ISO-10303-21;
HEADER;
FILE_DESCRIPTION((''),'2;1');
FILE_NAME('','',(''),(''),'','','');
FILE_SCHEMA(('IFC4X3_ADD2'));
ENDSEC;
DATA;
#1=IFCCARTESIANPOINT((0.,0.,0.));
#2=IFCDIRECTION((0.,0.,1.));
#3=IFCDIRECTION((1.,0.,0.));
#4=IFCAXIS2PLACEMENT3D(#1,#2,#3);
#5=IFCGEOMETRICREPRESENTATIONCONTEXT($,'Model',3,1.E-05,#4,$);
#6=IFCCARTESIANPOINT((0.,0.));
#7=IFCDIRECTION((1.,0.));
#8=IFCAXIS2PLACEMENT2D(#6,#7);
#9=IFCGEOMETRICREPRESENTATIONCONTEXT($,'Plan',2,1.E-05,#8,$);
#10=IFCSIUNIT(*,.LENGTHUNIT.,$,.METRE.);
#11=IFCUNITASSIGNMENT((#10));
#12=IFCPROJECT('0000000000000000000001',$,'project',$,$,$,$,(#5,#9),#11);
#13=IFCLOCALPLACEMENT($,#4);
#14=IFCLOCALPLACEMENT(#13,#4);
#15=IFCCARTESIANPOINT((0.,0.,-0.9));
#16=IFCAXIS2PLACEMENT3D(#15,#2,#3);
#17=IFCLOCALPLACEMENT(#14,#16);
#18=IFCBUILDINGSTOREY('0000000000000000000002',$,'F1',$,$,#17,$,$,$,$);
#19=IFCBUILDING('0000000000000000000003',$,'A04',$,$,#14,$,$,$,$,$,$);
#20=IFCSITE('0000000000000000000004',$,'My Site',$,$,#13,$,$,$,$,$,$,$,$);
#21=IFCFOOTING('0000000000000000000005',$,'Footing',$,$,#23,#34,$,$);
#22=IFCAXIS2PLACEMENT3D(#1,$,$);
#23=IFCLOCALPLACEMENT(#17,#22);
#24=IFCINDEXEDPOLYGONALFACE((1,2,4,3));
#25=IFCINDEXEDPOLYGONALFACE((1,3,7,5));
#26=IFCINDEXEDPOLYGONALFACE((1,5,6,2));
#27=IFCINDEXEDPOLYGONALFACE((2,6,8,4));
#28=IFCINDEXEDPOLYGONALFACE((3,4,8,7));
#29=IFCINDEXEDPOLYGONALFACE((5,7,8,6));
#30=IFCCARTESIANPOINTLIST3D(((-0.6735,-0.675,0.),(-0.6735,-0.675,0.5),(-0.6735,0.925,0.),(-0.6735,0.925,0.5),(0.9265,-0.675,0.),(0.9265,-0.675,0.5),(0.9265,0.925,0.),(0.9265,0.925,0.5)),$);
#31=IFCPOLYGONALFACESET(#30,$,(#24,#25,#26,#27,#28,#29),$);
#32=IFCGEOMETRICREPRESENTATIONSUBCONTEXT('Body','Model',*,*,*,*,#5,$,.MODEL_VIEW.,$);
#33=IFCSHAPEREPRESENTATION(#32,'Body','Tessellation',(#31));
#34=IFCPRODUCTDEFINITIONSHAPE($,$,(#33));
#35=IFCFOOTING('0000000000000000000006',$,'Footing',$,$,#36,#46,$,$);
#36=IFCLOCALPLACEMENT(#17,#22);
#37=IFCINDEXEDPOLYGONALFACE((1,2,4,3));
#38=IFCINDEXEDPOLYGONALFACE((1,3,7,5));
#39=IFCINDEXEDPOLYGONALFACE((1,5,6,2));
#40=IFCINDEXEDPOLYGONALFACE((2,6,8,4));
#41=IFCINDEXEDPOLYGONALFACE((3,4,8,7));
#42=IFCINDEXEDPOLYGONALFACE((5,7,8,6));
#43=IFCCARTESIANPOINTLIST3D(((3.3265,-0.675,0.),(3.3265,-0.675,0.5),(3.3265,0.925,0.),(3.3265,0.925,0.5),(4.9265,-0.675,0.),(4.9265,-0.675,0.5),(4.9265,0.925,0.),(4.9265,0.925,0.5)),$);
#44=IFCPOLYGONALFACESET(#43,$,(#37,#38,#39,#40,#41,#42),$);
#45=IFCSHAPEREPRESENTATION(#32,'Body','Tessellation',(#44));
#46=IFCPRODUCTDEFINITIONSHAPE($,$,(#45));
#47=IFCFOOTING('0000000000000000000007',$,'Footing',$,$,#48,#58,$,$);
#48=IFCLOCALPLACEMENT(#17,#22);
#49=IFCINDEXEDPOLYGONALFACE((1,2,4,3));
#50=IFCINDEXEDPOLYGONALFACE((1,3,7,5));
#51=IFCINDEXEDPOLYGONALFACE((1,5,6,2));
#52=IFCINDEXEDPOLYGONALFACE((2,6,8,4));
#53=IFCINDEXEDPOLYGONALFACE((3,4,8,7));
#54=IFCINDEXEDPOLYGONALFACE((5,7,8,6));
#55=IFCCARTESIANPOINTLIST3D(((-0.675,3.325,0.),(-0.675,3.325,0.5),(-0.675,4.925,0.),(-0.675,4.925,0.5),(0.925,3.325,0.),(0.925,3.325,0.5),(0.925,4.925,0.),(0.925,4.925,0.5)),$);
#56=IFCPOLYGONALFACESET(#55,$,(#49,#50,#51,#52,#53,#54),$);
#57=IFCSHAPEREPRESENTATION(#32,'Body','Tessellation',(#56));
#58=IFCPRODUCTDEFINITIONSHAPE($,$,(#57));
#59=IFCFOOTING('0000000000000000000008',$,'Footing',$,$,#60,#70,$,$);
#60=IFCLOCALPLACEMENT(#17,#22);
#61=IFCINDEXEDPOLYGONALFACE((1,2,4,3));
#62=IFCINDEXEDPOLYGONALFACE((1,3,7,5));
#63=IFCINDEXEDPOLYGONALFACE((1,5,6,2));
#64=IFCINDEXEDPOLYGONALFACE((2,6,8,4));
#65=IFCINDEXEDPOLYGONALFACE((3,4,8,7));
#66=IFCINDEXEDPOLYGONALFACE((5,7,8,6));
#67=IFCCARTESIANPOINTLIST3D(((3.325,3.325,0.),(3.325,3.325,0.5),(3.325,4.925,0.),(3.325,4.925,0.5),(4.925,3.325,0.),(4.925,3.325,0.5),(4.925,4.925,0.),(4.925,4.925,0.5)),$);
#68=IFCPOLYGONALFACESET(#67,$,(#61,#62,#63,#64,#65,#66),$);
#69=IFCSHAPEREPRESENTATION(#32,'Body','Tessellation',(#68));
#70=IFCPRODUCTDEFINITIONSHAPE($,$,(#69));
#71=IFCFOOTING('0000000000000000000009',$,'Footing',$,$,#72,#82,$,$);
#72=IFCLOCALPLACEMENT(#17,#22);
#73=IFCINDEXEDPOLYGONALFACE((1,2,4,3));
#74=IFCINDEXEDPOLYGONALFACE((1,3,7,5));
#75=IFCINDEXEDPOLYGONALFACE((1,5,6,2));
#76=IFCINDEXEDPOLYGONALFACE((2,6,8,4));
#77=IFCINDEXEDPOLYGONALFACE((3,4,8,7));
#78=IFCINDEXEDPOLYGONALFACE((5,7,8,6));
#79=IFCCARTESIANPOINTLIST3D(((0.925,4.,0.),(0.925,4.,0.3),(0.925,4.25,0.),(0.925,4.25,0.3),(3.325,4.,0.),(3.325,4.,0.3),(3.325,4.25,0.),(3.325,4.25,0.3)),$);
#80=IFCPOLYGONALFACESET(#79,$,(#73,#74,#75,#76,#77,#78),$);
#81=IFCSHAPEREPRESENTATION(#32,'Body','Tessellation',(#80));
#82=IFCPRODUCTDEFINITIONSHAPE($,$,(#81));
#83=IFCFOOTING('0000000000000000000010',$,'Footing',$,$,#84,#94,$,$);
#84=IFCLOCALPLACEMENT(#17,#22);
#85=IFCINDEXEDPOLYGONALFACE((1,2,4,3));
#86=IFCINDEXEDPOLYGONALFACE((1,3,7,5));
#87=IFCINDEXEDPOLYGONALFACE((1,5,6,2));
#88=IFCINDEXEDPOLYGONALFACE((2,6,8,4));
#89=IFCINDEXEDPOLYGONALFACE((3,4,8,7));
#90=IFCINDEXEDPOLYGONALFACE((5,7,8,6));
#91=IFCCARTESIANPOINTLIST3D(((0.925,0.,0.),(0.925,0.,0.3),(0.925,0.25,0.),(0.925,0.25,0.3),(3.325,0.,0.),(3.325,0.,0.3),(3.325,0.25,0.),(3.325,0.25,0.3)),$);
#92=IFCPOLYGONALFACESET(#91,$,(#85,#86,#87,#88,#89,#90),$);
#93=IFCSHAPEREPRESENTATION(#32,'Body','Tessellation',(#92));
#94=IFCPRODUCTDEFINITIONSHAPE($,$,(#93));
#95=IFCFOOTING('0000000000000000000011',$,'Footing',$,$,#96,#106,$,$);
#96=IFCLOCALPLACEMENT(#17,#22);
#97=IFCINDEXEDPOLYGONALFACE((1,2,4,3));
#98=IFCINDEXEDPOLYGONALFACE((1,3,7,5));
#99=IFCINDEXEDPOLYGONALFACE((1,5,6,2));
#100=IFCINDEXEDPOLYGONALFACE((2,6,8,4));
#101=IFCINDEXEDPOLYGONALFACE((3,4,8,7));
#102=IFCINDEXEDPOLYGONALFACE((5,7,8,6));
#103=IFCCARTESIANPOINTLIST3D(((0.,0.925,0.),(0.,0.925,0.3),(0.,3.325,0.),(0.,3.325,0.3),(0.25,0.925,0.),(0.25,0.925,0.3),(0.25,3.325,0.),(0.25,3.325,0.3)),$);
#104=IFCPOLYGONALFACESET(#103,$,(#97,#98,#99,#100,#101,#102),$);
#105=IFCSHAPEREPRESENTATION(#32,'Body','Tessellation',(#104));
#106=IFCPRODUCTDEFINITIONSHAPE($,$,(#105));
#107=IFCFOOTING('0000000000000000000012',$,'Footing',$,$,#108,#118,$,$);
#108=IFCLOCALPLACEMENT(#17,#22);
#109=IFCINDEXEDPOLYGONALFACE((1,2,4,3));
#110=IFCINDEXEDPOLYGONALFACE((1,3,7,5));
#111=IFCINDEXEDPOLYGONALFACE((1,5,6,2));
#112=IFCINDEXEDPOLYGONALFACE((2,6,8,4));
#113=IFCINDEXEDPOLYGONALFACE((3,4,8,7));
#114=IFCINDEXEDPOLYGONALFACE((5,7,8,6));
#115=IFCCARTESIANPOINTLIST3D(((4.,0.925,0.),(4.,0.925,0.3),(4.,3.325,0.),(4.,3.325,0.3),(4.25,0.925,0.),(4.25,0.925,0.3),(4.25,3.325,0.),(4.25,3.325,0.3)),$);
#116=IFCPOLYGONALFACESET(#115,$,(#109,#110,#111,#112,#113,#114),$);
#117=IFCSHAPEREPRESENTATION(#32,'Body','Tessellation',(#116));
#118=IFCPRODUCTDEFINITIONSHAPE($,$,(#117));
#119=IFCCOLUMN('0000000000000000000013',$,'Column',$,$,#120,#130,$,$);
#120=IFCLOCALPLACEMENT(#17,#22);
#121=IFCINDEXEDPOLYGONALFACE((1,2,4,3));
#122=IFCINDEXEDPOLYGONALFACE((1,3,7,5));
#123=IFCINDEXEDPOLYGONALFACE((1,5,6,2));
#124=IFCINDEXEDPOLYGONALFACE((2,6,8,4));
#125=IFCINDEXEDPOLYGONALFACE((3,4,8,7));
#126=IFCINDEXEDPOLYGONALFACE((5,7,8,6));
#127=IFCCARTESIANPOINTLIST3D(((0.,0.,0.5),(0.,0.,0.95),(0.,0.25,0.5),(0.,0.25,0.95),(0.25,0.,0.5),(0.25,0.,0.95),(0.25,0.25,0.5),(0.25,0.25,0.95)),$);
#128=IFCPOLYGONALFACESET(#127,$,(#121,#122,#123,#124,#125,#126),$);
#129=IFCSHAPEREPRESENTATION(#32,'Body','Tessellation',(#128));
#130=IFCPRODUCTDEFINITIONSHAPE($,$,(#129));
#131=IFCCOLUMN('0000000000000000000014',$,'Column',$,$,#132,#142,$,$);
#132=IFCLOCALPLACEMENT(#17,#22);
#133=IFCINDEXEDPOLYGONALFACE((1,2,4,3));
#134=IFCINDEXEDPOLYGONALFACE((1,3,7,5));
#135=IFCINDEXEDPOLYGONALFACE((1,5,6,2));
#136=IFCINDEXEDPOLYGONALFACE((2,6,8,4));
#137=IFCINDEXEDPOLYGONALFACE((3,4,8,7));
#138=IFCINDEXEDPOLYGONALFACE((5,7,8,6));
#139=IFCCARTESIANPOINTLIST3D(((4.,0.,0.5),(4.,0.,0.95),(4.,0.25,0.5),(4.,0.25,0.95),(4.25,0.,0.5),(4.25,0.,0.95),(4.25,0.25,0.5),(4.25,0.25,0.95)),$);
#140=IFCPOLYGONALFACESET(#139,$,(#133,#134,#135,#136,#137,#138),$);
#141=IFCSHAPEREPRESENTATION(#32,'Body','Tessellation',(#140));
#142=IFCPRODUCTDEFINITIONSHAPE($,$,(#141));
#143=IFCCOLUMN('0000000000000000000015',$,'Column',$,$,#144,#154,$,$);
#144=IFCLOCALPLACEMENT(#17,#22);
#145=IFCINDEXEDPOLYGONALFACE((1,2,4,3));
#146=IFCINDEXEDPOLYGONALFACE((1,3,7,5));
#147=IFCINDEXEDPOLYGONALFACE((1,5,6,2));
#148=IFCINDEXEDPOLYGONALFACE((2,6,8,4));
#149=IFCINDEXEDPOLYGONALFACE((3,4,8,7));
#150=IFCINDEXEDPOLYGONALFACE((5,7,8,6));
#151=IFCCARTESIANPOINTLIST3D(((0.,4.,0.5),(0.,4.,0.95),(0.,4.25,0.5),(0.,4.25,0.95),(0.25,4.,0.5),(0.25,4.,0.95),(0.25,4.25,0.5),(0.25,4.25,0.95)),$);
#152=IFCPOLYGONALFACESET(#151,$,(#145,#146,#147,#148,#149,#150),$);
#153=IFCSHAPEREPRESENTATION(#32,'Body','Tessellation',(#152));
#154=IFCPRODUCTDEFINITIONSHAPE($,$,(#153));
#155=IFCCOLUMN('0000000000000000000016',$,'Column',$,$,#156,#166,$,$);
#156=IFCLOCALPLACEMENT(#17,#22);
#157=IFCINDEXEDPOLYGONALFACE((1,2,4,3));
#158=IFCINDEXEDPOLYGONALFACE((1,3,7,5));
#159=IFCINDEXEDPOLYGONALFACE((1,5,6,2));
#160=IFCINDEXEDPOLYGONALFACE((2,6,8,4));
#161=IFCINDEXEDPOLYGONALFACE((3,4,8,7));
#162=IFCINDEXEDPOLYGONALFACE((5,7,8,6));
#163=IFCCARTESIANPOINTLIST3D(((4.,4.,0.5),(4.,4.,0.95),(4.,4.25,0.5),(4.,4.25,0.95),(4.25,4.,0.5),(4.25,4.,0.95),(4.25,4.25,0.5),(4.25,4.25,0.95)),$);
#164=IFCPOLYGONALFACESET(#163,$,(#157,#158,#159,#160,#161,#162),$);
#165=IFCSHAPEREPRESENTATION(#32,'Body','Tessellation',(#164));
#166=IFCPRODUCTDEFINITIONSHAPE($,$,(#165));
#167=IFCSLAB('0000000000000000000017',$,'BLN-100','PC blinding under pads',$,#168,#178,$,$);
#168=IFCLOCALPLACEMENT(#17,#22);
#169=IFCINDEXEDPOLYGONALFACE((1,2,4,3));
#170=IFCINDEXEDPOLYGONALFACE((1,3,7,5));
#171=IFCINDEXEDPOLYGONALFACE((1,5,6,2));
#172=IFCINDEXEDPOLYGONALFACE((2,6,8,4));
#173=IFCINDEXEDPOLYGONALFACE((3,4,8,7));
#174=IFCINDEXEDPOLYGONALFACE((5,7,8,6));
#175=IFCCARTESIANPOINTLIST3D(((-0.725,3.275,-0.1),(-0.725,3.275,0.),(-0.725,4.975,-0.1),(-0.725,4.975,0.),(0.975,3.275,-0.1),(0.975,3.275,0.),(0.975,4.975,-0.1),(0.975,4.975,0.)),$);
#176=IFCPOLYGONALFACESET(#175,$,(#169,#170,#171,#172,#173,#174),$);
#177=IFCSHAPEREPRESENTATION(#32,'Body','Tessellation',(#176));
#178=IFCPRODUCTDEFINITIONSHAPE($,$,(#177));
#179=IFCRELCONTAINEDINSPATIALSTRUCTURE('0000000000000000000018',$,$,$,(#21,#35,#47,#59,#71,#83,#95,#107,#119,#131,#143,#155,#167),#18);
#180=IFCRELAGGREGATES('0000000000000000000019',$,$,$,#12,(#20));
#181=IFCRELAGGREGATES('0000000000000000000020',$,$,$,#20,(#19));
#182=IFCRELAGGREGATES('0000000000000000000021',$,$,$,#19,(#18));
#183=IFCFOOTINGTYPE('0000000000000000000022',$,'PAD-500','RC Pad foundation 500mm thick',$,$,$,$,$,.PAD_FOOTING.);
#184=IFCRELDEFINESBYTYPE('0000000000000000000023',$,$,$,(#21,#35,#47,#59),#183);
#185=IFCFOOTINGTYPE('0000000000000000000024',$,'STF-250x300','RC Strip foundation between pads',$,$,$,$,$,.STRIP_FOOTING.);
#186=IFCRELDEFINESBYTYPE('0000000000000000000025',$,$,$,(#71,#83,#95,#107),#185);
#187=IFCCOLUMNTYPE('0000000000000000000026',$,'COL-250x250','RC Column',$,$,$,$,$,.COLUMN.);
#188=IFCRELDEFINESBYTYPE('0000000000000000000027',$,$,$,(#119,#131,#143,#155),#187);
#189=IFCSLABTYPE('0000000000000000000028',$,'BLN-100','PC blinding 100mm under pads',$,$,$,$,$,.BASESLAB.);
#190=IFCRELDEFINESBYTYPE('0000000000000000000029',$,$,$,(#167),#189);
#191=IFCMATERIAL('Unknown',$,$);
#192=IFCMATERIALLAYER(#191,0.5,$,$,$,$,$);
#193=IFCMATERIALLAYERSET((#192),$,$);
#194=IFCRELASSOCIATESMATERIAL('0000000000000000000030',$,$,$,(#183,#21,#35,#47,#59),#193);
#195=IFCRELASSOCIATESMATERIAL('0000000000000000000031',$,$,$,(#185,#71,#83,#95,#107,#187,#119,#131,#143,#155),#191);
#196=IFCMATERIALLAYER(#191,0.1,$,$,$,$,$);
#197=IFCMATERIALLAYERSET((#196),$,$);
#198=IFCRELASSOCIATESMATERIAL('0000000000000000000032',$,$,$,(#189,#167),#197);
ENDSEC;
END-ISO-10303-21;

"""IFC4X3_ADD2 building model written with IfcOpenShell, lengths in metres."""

from ifc_helpers import new_model, si_unit, frame, origin_with_axes, origin_2d_with_axis, place, context, subcontext, project, spatial, indexed_curve, rectangle, outline, extrude, material, layer, layer_set, layer_usage, material_profile, profile_set, profile_usage, type_object, element, save


model = new_model("IFC4X3_ADD2")

# Units and contexts
model_context = context("Model", 3, precision=1e-05, world=origin_with_axes())
plan_context = context("Plan", 2, precision=1e-05, world=origin_2d_with_axis())
body_context = subcontext(model_context, "Body", "Model", "MODEL_VIEW")
ifc_project = project(units=[si_unit("LENGTHUNIT", "METRE")], contexts=[model_context, plan_context])

# Site, building, storey
site_placement = place(None, origin_with_axes())
site = spatial("IfcSite", under=ifc_project, at=site_placement, Name="My Site")
building_placement = place(site_placement, origin_with_axes())
building = spatial("IfcBuilding", under=site, at=building_placement, Name="A04")
storey_placement = place(building_placement, frame((0.0, 0.0, -0.9), z_axis=(0.0, 0.0, 1.0), x_axis=(1.0, 0.0, 0.0)))
storey = spatial("IfcBuildingStorey", under=building, at=storey_placement, Name="F1")

# Footings
ifc_material_1 = material(Name="Unknown")
ifc_layer_1 = layer(ifc_material_1, 0.5)
ifc_layer_set_1 = layer_set([ifc_layer_1])
ifc_layer_usage_1 = layer_usage(ifc_layer_set_1, "AXIS3", "POSITIVE", -0.5)
footing_type_1 = type_object("IfcFootingType", Name="PAD-500", Description="RC Pad foundation 500mm thick", PredefinedType="PAD_FOOTING", material=ifc_layer_set_1)
footing_1_placement = place(storey_placement, frame((-0.6735, 0.925, 0.5), z_axis=(0.0, 0.0, 1.0), x_axis=(1.0, 0.0, 0.0)))
element("IfcFooting", 1, at=footing_1_placement, inside=storey, type_object=footing_type_1, material=ifc_layer_usage_1, Name="Footing", context=body_context, shape_type="SweptSolid", body=[
    extrude(outline(indexed_curve([(0.0, -1.6), (1.6, -1.6), (1.6, 0.0), (0.0, 0.0), (0.0, -1.6)])), frame((0.0, 0.0, -0.5), z_axis=(0.0, 0.0, 1.0), x_axis=(1.0, 0.0, 0.0)), (0.0, 0.0, 1.0), 0.5),
])
ifc_layer_usage_2 = layer_usage(ifc_layer_set_1, "AXIS3", "POSITIVE", -0.5)
footing_2_placement = place(storey_placement, frame((3.3265, 0.925, 0.5), z_axis=(0.0, 0.0, 1.0), x_axis=(1.0, 0.0, 0.0)))
element("IfcFooting", 2, at=footing_2_placement, inside=storey, type_object=footing_type_1, material=ifc_layer_usage_2, Name="Footing", context=body_context, shape_type="SweptSolid", body=[
    extrude(outline(indexed_curve([(0.0, -1.6), (1.6, -1.6), (1.6, 0.0), (0.0, 0.0), (0.0, -1.6)])), frame((0.0, 0.0, -0.5), z_axis=(0.0, 0.0, 1.0), x_axis=(1.0, 0.0, 0.0)), (0.0, 0.0, 1.0), 0.5),
])
ifc_layer_usage_3 = layer_usage(ifc_layer_set_1, "AXIS3", "POSITIVE", -0.5)
footing_3_placement = place(storey_placement, frame((-0.675, 4.925, 0.5), z_axis=(0.0, 0.0, 1.0), x_axis=(1.0, 0.0, 0.0)))
element("IfcFooting", 3, at=footing_3_placement, inside=storey, type_object=footing_type_1, material=ifc_layer_usage_3, Name="Footing", context=body_context, shape_type="SweptSolid", body=[
    extrude(outline(indexed_curve([(0.0, -1.6), (1.6, -1.6), (1.6, 0.0), (0.0, 0.0), (0.0, -1.6)])), frame((0.0, 0.0, -0.5), z_axis=(0.0, 0.0, 1.0), x_axis=(1.0, 0.0, 0.0)), (0.0, 0.0, 1.0), 0.5),
])
ifc_layer_usage_4 = layer_usage(ifc_layer_set_1, "AXIS3", "POSITIVE", -0.5)
footing_4_placement = place(storey_placement, frame((3.325, 4.925, 0.5), z_axis=(0.0, 0.0, 1.0), x_axis=(1.0, 0.0, 0.0)))
element("IfcFooting", 4, at=footing_4_placement, inside=storey, type_object=footing_type_1, material=ifc_layer_usage_4, Name="Footing", context=body_context, shape_type="SweptSolid", body=[
    extrude(outline(indexed_curve([(0.0, -1.6), (1.6, -1.6), (1.6, 0.0), (0.0, 0.0), (0.0, -1.6)])), frame((0.0, 0.0, -0.5), z_axis=(0.0, 0.0, 1.0), x_axis=(1.0, 0.0, 0.0)), (0.0, 0.0, 1.0), 0.5),
])
ifc_material_profile_1 = material_profile(ifc_material_1, rectangle(XDim=0.25, YDim=0.3))
ifc_profile_set_1 = profile_set([ifc_material_profile_1])
ifc_profile_usage_1 = profile_usage(ifc_profile_set_1, cardinal=2)
footing_type_2 = type_object("IfcFootingType", Name="STF-250x300", Description="RC Strip foundation between pads", PredefinedType="STRIP_FOOTING", material=ifc_profile_set_1)
footing_5_placement = place(storey_placement, frame((0.925, 4.125, 0.0), z_axis=(1.0, 0.0, 0.0), x_axis=(0.0, 1.0, 0.0)))
element("IfcFooting", 5, at=footing_5_placement, inside=storey, type_object=footing_type_2, material=ifc_profile_usage_1, Name="Footing", context=body_context, shape_type="SweptSolid", body=[
    extrude(rectangle(XDim=0.25, YDim=0.3), frame((0.0, 0.15, 0.0), z_axis=(0.0, 0.0, 1.0), x_axis=(1.0, 0.0, 0.0)), (0.0, 0.0, 1.0), 2.4),
])
ifc_profile_usage_2 = profile_usage(ifc_profile_set_1, cardinal=2)
footing_6_placement = place(storey_placement, frame((0.925, 0.125, 0.0), z_axis=(1.0, 0.0, 0.0), x_axis=(0.0, 1.0, 0.0)))
element("IfcFooting", 6, at=footing_6_placement, inside=storey, type_object=footing_type_2, material=ifc_profile_usage_2, Name="Footing", context=body_context, shape_type="SweptSolid", body=[
    extrude(rectangle(XDim=0.25, YDim=0.3), frame((0.0, 0.15, 0.0), z_axis=(0.0, 0.0, 1.0), x_axis=(1.0, 0.0, 0.0)), (0.0, 0.0, 1.0), 2.4),
])
ifc_profile_usage_3 = profile_usage(ifc_profile_set_1, cardinal=2)
footing_7_placement = place(storey_placement, frame((0.125, 0.925, 0.0), z_axis=(0.0, 1.0, 0.0), x_axis=(-1.0, 0.0, 0.0)))
element("IfcFooting", 7, at=footing_7_placement, inside=storey, type_object=footing_type_2, material=ifc_profile_usage_3, Name="Footing", context=body_context, shape_type="SweptSolid", body=[
    extrude(rectangle(XDim=0.25, YDim=0.3), frame((0.0, 0.15, 0.0), z_axis=(0.0, 0.0, 1.0), x_axis=(1.0, 0.0, 0.0)), (0.0, 0.0, 1.0), 2.4),
])
ifc_profile_usage_4 = profile_usage(ifc_profile_set_1, cardinal=2)
footing_8_placement = place(storey_placement, frame((4.125, 0.925, 0.0), z_axis=(0.0, 1.0, 0.0), x_axis=(-1.0, 0.0, 0.0)))
element("IfcFooting", 8, at=footing_8_placement, inside=storey, type_object=footing_type_2, material=ifc_profile_usage_4, Name="Footing", context=body_context, shape_type="SweptSolid", body=[
    extrude(rectangle(XDim=0.25, YDim=0.3), frame((0.0, 0.15, 0.0), z_axis=(0.0, 0.0, 1.0), x_axis=(1.0, 0.0, 0.0)), (0.0, 0.0, 1.0), 2.4),
])

# Columns
ifc_material_profile_2 = material_profile(ifc_material_1, rectangle(XDim=0.25, YDim=0.25))
ifc_profile_set_2 = profile_set([ifc_material_profile_2])
ifc_profile_usage_5 = profile_usage(ifc_profile_set_2, cardinal=5)
column_type = type_object("IfcColumnType", Name="COL-250x250", Description="RC Column", PredefinedType="COLUMN", material=ifc_profile_set_2)
column_1_placement = place(storey_placement, frame((0.125, 0.125, 0.5), z_axis=(0.0, 0.0, 1.0), x_axis=(1.0, 0.0, 0.0)))
element("IfcColumn", 9, at=column_1_placement, inside=storey, type_object=column_type, material=ifc_profile_usage_5, Name="Column", context=body_context, shape_type="SweptSolid", body=[
    extrude(rectangle(XDim=0.25, YDim=0.25), origin_with_axes(), (0.0, 0.0, 1.0), 0.45),
])
ifc_profile_usage_6 = profile_usage(ifc_profile_set_2, cardinal=5)
column_2_placement = place(storey_placement, frame((4.125, 0.125, 0.5), z_axis=(0.0, 0.0, 1.0), x_axis=(1.0, 0.0, 0.0)))
element("IfcColumn", 10, at=column_2_placement, inside=storey, type_object=column_type, material=ifc_profile_usage_6, Name="Column", context=body_context, shape_type="SweptSolid", body=[
    extrude(rectangle(XDim=0.25, YDim=0.25), origin_with_axes(), (0.0, 0.0, 1.0), 0.45),
])
ifc_profile_usage_7 = profile_usage(ifc_profile_set_2, cardinal=5)
column_3_placement = place(storey_placement, frame((0.125, 4.125, 0.5), z_axis=(0.0, 0.0, 1.0), x_axis=(1.0, 0.0, 0.0)))
element("IfcColumn", 11, at=column_3_placement, inside=storey, type_object=column_type, material=ifc_profile_usage_7, Name="Column", context=body_context, shape_type="SweptSolid", body=[
    extrude(rectangle(XDim=0.25, YDim=0.25), origin_with_axes(), (0.0, 0.0, 1.0), 0.45),
])
ifc_profile_usage_8 = profile_usage(ifc_profile_set_2, cardinal=5)
column_4_placement = place(storey_placement, frame((4.125, 4.125, 0.5), z_axis=(0.0, 0.0, 1.0), x_axis=(1.0, 0.0, 0.0)))
element("IfcColumn", 12, at=column_4_placement, inside=storey, type_object=column_type, material=ifc_profile_usage_8, Name="Column", context=body_context, shape_type="SweptSolid", body=[
    extrude(rectangle(XDim=0.25, YDim=0.25), origin_with_axes(), (0.0, 0.0, 1.0), 0.45),
])

# Slab
ifc_layer_2 = layer(ifc_material_1, 0.1)
ifc_layer_set_2 = layer_set([ifc_layer_2])
ifc_layer_usage_5 = layer_usage(ifc_layer_set_2, "AXIS3", "POSITIVE", -0.1)
slab_type_1 = type_object("IfcSlabType", Name="BLN-100", Description="PC blinding 100mm under pads", PredefinedType="BASESLAB", material=ifc_layer_set_2)
slab_1_placement = place(storey_placement, frame((-0.725, 4.975, 0.0), z_axis=(0.0, 0.0, 1.0), x_axis=(1.0, 0.0, 0.0)))
element("IfcSlab", 13, at=slab_1_placement, inside=storey, type_object=slab_type_1, material=ifc_layer_usage_5, Name="BLN-100", Description="PC blinding under pads", context=body_context, shape_type="SweptSolid", body=[
    extrude(outline(indexed_curve([(0.0, 0.0), (1.7, 0.0), (1.7, -1.7), (0.0, -1.7), (0.0, 0.0)])), frame((0.0, 0.0, -0.1), z_axis=(0.0, 0.0, 1.0), x_axis=(1.0, 0.0, 0.0)), (0.0, 0.0, 1.0), 0.1),
])

save(model, "model.ifc")
